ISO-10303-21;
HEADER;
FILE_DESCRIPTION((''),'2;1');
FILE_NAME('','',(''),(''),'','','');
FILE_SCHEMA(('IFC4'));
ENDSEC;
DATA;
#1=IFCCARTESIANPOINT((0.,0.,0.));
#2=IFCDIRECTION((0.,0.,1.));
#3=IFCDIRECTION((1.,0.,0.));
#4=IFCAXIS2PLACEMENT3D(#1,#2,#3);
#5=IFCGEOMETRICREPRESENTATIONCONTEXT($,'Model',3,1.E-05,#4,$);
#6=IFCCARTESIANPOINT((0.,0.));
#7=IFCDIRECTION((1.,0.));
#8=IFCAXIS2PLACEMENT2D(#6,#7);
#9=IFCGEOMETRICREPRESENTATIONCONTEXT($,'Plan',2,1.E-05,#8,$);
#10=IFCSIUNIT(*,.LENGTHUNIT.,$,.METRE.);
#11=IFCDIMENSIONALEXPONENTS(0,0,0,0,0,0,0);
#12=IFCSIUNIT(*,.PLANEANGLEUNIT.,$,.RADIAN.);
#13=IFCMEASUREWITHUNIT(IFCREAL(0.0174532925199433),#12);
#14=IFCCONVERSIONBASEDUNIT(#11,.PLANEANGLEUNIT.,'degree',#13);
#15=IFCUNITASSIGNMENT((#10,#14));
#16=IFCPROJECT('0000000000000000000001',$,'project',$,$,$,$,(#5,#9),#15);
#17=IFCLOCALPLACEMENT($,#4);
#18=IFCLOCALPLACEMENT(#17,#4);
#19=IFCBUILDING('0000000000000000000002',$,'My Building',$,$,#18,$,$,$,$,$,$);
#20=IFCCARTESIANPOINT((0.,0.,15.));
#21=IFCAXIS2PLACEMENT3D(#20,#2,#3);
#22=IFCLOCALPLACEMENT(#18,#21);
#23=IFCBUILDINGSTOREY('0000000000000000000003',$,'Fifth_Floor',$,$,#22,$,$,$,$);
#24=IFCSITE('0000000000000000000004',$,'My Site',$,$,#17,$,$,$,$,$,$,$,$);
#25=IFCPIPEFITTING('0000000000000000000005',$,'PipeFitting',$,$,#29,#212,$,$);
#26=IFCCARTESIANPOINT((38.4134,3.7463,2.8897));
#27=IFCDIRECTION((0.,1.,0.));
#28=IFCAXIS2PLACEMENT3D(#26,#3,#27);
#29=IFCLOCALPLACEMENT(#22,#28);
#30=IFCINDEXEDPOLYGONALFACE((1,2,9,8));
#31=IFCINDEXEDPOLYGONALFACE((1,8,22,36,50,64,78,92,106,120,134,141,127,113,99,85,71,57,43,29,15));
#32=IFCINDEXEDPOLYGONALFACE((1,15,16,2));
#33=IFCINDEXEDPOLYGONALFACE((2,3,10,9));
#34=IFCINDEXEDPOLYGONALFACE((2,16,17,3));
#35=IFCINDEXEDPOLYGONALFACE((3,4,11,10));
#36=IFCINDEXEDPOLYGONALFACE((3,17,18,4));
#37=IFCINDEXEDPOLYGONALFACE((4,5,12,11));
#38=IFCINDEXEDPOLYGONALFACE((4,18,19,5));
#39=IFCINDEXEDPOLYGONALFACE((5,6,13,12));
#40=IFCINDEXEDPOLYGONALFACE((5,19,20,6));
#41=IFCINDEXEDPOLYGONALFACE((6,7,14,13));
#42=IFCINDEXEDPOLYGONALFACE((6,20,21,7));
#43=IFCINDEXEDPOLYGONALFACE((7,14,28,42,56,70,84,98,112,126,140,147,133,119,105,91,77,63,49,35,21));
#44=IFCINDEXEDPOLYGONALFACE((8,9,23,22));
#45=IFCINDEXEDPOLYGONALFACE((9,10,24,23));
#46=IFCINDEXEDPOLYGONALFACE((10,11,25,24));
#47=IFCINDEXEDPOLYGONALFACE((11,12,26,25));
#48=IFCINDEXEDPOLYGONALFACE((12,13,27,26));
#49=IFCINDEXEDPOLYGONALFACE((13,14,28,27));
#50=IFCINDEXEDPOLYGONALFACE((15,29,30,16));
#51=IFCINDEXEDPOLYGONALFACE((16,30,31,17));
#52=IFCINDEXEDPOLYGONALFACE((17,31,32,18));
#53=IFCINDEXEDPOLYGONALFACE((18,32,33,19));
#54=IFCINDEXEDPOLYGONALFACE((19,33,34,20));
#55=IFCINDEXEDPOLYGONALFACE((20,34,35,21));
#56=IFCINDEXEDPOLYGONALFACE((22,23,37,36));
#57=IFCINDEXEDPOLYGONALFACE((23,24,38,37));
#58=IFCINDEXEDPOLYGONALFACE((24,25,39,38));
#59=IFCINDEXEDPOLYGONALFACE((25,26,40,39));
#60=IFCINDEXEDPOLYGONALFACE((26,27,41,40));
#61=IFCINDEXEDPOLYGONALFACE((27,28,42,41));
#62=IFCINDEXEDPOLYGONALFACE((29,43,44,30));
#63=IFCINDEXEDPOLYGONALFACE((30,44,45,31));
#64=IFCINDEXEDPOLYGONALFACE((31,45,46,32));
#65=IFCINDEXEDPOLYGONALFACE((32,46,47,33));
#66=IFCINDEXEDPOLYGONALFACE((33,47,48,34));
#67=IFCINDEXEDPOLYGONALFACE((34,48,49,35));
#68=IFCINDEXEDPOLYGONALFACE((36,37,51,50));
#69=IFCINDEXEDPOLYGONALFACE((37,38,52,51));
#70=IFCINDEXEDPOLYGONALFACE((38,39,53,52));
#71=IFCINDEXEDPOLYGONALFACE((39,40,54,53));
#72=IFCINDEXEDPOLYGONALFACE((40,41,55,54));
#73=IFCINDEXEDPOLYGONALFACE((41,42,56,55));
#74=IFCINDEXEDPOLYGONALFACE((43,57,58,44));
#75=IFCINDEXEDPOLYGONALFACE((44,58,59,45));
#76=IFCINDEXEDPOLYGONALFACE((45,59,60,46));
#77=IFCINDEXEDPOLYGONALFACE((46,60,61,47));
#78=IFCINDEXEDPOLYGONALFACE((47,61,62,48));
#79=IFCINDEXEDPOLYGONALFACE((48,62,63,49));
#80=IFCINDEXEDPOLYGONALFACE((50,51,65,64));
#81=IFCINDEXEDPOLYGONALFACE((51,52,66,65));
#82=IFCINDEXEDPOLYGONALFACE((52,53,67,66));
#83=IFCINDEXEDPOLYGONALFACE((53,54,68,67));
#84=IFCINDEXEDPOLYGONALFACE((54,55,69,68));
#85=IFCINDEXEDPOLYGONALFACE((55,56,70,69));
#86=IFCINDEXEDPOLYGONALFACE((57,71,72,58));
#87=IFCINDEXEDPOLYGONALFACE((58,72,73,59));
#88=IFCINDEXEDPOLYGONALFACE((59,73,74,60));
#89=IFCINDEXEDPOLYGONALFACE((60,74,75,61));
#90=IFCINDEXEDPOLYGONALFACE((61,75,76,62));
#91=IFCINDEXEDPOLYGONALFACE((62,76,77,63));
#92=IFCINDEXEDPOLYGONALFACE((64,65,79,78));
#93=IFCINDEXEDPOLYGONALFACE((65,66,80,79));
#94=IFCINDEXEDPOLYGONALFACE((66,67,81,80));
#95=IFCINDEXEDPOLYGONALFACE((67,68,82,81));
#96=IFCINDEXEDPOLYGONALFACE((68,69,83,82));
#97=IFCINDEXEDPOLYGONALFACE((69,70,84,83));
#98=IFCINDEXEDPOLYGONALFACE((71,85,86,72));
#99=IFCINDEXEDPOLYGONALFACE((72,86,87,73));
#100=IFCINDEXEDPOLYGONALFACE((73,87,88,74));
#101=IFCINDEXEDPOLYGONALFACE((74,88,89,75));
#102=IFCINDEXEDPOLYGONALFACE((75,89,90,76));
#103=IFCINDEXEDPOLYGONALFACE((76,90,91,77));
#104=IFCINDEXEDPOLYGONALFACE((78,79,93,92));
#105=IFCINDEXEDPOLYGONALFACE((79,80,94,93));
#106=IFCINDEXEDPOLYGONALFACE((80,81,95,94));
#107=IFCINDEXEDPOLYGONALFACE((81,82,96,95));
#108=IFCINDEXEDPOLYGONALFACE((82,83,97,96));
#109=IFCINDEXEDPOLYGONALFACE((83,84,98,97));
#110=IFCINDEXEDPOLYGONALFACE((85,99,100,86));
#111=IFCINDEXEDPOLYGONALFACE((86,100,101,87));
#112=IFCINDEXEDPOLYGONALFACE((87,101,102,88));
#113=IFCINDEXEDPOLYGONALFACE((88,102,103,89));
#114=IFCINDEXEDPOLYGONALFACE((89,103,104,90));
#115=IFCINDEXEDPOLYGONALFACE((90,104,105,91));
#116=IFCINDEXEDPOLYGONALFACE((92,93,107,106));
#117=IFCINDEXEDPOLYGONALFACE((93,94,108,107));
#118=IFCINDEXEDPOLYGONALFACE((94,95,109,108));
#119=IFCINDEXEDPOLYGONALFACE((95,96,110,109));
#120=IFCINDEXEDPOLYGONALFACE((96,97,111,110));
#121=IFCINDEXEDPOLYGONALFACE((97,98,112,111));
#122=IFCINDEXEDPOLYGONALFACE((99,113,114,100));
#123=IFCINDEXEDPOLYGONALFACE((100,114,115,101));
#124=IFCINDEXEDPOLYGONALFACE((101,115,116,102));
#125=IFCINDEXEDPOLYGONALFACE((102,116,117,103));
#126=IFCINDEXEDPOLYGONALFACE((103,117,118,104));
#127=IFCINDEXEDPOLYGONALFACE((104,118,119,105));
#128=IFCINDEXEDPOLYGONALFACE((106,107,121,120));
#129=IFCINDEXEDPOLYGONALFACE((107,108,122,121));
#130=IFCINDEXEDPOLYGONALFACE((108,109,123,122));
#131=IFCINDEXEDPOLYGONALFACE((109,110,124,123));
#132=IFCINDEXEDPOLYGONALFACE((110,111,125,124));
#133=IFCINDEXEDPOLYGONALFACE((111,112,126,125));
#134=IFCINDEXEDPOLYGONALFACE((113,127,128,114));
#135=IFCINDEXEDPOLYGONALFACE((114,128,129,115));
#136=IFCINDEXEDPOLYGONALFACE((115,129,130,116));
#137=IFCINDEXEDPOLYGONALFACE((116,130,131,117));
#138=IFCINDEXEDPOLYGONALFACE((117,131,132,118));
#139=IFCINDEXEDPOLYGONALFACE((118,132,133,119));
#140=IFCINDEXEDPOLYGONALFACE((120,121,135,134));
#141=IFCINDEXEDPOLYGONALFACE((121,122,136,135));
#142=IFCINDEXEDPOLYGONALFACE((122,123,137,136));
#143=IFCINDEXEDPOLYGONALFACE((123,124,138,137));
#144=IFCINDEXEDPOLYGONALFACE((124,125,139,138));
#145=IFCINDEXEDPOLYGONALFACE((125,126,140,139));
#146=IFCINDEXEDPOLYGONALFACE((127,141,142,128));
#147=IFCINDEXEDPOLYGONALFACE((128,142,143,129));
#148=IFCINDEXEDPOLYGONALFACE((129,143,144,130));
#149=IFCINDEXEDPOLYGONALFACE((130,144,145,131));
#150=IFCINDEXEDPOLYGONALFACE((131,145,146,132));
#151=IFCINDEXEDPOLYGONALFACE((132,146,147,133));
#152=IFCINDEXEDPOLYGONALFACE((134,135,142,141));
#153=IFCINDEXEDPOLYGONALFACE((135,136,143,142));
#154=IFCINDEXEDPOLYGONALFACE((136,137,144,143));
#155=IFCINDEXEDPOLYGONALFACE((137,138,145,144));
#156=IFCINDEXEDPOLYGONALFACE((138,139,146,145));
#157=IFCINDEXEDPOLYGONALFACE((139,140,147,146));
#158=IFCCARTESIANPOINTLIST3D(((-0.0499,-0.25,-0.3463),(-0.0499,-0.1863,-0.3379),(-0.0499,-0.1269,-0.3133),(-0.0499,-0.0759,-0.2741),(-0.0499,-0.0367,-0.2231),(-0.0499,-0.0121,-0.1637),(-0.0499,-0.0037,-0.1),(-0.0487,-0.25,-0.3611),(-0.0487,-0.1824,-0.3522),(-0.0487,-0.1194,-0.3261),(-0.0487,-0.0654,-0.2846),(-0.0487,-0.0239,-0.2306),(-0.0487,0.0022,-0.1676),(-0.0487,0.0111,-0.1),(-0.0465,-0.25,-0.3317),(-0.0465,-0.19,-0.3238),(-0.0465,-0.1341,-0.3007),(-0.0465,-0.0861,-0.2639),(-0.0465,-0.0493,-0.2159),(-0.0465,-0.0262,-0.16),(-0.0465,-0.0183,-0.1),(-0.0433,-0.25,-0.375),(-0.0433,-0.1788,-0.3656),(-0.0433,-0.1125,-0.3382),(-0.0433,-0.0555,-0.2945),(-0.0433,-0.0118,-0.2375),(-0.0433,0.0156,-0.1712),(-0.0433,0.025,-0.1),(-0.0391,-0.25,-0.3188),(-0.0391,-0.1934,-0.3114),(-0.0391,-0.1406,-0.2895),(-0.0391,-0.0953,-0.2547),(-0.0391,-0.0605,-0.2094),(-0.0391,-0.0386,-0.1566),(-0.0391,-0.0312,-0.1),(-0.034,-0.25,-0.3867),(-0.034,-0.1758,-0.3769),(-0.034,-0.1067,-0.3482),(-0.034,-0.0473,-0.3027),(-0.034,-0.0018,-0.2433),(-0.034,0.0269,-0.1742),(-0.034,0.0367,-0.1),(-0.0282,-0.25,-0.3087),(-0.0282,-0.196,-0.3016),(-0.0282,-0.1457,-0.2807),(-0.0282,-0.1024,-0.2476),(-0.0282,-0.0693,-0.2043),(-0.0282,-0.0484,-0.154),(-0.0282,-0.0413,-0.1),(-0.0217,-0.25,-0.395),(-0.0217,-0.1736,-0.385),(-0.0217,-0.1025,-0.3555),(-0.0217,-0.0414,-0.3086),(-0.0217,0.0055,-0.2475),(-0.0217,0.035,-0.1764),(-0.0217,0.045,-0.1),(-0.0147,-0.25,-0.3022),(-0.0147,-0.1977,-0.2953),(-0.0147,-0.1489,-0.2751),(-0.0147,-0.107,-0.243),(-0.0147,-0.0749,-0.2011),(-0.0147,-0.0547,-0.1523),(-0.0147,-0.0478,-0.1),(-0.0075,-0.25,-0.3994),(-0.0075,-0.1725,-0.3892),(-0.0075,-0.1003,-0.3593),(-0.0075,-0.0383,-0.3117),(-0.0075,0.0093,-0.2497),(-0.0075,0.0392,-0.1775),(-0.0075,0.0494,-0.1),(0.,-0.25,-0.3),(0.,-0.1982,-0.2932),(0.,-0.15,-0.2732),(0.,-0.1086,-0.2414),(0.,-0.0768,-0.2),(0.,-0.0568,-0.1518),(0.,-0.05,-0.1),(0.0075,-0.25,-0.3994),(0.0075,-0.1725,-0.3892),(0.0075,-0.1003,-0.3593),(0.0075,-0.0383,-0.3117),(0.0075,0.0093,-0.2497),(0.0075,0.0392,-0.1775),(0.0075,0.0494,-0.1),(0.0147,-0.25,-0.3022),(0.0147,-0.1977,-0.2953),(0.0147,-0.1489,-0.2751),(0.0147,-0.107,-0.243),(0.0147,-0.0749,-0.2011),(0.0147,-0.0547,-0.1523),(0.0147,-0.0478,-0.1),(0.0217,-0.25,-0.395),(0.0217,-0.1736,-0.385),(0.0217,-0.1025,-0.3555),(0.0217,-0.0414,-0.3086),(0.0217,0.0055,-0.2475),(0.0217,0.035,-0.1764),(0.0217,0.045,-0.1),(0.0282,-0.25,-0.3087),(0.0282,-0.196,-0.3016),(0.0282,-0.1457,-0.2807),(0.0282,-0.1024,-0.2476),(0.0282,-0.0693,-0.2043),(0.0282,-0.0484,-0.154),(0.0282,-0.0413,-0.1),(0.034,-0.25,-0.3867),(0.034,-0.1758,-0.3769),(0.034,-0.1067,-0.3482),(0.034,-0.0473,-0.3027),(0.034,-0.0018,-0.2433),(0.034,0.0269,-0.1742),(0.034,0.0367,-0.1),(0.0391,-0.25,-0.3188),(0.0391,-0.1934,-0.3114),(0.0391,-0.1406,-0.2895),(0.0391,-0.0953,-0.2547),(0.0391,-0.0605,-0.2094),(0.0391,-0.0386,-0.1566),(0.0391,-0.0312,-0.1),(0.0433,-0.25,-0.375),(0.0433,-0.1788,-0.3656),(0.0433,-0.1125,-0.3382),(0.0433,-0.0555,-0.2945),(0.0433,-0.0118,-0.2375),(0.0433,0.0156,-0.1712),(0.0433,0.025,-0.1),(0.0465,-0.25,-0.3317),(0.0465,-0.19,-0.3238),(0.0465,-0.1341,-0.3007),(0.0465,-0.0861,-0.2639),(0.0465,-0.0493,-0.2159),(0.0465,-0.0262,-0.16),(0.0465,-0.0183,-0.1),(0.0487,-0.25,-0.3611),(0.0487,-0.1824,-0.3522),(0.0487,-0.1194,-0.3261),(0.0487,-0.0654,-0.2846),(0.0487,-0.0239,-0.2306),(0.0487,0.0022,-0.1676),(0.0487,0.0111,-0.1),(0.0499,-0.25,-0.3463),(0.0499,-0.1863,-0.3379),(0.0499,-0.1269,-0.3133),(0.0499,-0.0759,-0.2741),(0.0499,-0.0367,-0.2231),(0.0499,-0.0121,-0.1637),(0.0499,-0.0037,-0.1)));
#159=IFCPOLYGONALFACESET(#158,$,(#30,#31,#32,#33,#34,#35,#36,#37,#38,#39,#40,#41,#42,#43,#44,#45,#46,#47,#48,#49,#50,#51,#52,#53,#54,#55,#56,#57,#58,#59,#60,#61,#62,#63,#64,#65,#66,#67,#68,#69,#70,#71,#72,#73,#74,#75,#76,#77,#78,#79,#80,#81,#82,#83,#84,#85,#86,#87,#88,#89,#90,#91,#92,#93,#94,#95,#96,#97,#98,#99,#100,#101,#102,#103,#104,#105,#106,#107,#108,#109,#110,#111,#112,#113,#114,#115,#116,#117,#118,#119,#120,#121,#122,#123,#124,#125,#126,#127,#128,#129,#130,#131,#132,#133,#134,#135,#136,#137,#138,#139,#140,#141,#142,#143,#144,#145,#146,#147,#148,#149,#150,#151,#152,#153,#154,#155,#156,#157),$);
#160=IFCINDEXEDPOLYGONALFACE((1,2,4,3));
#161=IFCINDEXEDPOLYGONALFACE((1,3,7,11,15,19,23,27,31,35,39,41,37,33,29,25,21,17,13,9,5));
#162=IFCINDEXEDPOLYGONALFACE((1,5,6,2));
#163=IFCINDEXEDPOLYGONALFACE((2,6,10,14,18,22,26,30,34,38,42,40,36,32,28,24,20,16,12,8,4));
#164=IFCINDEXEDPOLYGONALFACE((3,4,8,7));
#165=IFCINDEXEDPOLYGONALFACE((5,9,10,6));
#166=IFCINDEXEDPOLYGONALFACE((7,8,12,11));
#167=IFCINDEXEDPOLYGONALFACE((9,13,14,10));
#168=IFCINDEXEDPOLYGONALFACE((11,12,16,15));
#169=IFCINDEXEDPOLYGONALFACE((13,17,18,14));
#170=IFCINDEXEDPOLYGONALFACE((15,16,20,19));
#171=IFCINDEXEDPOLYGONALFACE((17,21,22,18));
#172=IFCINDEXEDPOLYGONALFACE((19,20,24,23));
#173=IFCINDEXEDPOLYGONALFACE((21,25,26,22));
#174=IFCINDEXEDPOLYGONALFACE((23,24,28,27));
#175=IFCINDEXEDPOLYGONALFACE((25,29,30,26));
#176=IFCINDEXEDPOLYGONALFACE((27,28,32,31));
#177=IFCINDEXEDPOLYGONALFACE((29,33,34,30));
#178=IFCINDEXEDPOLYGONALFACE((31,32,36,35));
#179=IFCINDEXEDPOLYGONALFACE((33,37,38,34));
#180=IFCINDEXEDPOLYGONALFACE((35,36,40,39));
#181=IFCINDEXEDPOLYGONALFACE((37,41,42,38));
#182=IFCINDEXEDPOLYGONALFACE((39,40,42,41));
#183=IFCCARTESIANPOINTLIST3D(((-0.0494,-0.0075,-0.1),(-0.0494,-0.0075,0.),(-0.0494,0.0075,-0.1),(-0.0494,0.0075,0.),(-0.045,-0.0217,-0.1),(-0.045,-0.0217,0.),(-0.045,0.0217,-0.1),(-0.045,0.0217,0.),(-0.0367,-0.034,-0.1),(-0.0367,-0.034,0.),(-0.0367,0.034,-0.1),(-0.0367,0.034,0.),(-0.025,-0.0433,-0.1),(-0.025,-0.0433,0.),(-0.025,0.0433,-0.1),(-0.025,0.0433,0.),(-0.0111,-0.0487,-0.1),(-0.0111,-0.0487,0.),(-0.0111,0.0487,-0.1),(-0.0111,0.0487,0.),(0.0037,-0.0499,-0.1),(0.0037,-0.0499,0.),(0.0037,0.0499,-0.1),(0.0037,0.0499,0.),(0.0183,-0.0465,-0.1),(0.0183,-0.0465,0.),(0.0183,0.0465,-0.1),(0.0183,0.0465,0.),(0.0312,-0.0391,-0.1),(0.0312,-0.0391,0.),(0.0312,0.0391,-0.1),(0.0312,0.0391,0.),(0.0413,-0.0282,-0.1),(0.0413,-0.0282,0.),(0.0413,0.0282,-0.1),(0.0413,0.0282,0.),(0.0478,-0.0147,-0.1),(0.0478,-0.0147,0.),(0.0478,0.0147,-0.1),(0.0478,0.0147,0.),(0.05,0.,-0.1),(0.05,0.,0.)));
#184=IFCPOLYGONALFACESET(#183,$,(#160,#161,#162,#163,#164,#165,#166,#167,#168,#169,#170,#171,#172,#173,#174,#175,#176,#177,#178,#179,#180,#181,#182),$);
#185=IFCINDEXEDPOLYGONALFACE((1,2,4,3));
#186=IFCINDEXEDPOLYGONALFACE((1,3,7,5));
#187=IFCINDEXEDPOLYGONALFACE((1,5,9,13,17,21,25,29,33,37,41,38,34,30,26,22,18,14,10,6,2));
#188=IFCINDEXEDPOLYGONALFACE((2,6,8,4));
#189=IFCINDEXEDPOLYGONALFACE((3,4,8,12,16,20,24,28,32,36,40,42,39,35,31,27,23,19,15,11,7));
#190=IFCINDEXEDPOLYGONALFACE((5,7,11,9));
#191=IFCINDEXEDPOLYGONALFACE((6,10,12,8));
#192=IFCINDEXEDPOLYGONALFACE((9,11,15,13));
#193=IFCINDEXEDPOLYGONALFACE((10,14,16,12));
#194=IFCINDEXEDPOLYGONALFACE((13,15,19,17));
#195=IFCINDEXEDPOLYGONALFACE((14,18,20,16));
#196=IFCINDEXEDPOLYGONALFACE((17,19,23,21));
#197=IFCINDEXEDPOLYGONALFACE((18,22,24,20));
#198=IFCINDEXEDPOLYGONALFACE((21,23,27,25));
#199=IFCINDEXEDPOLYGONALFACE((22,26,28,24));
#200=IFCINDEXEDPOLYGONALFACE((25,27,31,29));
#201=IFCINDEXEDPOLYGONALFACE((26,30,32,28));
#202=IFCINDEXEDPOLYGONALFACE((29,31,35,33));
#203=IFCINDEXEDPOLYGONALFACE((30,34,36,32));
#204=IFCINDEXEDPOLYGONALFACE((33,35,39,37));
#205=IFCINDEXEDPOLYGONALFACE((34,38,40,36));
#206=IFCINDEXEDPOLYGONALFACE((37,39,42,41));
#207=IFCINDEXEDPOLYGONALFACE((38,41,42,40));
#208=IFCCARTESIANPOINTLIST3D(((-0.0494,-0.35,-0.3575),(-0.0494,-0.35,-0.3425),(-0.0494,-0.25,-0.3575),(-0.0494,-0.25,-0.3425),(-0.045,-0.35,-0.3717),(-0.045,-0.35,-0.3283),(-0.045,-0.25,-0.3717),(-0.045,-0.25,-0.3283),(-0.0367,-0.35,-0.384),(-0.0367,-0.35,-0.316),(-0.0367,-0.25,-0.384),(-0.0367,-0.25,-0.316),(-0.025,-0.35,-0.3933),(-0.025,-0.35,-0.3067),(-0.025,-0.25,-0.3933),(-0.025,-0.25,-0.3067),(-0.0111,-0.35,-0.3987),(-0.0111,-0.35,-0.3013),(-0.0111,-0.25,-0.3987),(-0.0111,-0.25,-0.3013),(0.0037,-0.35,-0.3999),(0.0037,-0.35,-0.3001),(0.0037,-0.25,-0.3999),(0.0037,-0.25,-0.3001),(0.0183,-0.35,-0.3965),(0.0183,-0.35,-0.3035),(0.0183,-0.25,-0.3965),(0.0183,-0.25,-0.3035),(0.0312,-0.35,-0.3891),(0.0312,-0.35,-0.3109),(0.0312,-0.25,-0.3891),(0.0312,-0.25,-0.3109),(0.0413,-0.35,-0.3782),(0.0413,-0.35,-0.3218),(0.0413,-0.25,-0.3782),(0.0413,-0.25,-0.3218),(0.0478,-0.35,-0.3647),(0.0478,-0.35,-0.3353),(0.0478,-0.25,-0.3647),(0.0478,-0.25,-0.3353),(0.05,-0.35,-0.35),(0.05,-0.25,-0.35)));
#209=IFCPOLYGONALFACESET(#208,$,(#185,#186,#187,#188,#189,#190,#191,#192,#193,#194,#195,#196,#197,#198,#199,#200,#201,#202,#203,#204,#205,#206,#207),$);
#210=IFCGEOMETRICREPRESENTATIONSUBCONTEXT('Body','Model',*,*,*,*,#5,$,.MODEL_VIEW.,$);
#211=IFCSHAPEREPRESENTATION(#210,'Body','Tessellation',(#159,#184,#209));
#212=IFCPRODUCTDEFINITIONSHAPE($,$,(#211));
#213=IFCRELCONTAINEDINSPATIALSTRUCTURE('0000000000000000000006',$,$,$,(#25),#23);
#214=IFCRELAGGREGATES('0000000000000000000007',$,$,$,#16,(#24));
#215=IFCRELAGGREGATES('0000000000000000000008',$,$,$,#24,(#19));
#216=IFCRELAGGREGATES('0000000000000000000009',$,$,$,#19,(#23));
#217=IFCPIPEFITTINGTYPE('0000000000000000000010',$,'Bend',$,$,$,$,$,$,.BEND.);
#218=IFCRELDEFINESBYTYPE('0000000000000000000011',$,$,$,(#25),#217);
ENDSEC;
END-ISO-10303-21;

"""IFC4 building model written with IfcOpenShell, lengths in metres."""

from ifc_helpers import new_model, entity, si_unit, converted_unit, frame, origin_with_axes, origin_2d_with_axis, place, context, subcontext, project, spatial, circle, extrude, source, transform, mapped, type_object, type_shapes, element, save


model = new_model("IFC4")

# Units and contexts
model_context = context("Model", 3, precision=1e-05, world=origin_with_axes())
plan_context = context("Plan", 2, precision=1e-05, world=origin_2d_with_axis())
body_context_1 = subcontext(model_context, "Body", "Model", "MODEL_VIEW")
ifc_project = project(units=[si_unit("LENGTHUNIT", "METRE"), converted_unit("PLANEANGLEUNIT", "degree", entity("IfcReal", 0.0174532925199433), si_unit("PLANEANGLEUNIT", "RADIAN"), dimensions=[0, 0, 0, 0, 0, 0, 0])], contexts=[model_context, plan_context])

# Site, building, storey
site_placement = place(None, origin_with_axes())
site = spatial("IfcSite", under=ifc_project, at=site_placement, Name="My Site")
building_placement = place(site_placement, origin_with_axes())
building = spatial("IfcBuilding", under=site, at=building_placement, Name="My Building")
storey_placement = place(building_placement, frame((0.0, 0.0, 15.0), z_axis=(0.0, 0.0, 1.0), x_axis=(1.0, 0.0, 0.0)))
storey = spatial("IfcBuildingStorey", under=building, at=storey_placement, Name="Fifth_Floor")

# Pipe fitting
pipe_fitting_type = type_object("IfcPipeFittingType", Name="Bend", PredefinedType="BEND")
shared_shape_1 = source(origin_with_axes(), body_context_1, "Body", "SolidModel", [
    entity("IfcSweptDiskSolid", entity("IfcIndexedPolyCurve", entity("IfcCartesianPointList3D", [[0.0, 0.0, -0.1], [0.0, -0.0732, -0.2768], [0.0, -0.25, -0.35]]), [entity("IfcArcIndex", [1, 2, 3])]), 0.05),
    extrude(circle(Radius=0.05), origin_with_axes(), (0.0, 0.0, -1.0), 0.1),
    extrude(circle(Radius=0.05), frame((0.0, -0.25, -0.35), z_axis=(0.0, -1.0, 0.0), x_axis=(1.0, 0.0, 0.0)), (0.0, 0.0, 1.0), 0.1),
])
type_shapes(pipe_fitting_type, [shared_shape_1])
for number, where, z_axis, x_axis, name in (
    (1, (38.4134, 3.7463, 2.8897), (1.0, 0.0, 0.0), (0.0, 1.0, 0.0), "PipeFitting"),
):
    element("IfcPipeFitting", number, at=place(storey_placement, frame(where, z_axis=z_axis, x_axis=x_axis)), inside=storey, type_object=pipe_fitting_type, Name=name, context=body_context_1, shape_type="MappedRepresentation", body=[
        mapped(shared_shape_1, transform((0.0, 0.0, 0.0), x_axis=(1.0, 0.0, 0.0), y_axis=(0.0, 1.0, 0.0), z_axis=(0.0, 0.0, 1.0), scale=1.0)),
    ])

save(model, "model.ifc")
